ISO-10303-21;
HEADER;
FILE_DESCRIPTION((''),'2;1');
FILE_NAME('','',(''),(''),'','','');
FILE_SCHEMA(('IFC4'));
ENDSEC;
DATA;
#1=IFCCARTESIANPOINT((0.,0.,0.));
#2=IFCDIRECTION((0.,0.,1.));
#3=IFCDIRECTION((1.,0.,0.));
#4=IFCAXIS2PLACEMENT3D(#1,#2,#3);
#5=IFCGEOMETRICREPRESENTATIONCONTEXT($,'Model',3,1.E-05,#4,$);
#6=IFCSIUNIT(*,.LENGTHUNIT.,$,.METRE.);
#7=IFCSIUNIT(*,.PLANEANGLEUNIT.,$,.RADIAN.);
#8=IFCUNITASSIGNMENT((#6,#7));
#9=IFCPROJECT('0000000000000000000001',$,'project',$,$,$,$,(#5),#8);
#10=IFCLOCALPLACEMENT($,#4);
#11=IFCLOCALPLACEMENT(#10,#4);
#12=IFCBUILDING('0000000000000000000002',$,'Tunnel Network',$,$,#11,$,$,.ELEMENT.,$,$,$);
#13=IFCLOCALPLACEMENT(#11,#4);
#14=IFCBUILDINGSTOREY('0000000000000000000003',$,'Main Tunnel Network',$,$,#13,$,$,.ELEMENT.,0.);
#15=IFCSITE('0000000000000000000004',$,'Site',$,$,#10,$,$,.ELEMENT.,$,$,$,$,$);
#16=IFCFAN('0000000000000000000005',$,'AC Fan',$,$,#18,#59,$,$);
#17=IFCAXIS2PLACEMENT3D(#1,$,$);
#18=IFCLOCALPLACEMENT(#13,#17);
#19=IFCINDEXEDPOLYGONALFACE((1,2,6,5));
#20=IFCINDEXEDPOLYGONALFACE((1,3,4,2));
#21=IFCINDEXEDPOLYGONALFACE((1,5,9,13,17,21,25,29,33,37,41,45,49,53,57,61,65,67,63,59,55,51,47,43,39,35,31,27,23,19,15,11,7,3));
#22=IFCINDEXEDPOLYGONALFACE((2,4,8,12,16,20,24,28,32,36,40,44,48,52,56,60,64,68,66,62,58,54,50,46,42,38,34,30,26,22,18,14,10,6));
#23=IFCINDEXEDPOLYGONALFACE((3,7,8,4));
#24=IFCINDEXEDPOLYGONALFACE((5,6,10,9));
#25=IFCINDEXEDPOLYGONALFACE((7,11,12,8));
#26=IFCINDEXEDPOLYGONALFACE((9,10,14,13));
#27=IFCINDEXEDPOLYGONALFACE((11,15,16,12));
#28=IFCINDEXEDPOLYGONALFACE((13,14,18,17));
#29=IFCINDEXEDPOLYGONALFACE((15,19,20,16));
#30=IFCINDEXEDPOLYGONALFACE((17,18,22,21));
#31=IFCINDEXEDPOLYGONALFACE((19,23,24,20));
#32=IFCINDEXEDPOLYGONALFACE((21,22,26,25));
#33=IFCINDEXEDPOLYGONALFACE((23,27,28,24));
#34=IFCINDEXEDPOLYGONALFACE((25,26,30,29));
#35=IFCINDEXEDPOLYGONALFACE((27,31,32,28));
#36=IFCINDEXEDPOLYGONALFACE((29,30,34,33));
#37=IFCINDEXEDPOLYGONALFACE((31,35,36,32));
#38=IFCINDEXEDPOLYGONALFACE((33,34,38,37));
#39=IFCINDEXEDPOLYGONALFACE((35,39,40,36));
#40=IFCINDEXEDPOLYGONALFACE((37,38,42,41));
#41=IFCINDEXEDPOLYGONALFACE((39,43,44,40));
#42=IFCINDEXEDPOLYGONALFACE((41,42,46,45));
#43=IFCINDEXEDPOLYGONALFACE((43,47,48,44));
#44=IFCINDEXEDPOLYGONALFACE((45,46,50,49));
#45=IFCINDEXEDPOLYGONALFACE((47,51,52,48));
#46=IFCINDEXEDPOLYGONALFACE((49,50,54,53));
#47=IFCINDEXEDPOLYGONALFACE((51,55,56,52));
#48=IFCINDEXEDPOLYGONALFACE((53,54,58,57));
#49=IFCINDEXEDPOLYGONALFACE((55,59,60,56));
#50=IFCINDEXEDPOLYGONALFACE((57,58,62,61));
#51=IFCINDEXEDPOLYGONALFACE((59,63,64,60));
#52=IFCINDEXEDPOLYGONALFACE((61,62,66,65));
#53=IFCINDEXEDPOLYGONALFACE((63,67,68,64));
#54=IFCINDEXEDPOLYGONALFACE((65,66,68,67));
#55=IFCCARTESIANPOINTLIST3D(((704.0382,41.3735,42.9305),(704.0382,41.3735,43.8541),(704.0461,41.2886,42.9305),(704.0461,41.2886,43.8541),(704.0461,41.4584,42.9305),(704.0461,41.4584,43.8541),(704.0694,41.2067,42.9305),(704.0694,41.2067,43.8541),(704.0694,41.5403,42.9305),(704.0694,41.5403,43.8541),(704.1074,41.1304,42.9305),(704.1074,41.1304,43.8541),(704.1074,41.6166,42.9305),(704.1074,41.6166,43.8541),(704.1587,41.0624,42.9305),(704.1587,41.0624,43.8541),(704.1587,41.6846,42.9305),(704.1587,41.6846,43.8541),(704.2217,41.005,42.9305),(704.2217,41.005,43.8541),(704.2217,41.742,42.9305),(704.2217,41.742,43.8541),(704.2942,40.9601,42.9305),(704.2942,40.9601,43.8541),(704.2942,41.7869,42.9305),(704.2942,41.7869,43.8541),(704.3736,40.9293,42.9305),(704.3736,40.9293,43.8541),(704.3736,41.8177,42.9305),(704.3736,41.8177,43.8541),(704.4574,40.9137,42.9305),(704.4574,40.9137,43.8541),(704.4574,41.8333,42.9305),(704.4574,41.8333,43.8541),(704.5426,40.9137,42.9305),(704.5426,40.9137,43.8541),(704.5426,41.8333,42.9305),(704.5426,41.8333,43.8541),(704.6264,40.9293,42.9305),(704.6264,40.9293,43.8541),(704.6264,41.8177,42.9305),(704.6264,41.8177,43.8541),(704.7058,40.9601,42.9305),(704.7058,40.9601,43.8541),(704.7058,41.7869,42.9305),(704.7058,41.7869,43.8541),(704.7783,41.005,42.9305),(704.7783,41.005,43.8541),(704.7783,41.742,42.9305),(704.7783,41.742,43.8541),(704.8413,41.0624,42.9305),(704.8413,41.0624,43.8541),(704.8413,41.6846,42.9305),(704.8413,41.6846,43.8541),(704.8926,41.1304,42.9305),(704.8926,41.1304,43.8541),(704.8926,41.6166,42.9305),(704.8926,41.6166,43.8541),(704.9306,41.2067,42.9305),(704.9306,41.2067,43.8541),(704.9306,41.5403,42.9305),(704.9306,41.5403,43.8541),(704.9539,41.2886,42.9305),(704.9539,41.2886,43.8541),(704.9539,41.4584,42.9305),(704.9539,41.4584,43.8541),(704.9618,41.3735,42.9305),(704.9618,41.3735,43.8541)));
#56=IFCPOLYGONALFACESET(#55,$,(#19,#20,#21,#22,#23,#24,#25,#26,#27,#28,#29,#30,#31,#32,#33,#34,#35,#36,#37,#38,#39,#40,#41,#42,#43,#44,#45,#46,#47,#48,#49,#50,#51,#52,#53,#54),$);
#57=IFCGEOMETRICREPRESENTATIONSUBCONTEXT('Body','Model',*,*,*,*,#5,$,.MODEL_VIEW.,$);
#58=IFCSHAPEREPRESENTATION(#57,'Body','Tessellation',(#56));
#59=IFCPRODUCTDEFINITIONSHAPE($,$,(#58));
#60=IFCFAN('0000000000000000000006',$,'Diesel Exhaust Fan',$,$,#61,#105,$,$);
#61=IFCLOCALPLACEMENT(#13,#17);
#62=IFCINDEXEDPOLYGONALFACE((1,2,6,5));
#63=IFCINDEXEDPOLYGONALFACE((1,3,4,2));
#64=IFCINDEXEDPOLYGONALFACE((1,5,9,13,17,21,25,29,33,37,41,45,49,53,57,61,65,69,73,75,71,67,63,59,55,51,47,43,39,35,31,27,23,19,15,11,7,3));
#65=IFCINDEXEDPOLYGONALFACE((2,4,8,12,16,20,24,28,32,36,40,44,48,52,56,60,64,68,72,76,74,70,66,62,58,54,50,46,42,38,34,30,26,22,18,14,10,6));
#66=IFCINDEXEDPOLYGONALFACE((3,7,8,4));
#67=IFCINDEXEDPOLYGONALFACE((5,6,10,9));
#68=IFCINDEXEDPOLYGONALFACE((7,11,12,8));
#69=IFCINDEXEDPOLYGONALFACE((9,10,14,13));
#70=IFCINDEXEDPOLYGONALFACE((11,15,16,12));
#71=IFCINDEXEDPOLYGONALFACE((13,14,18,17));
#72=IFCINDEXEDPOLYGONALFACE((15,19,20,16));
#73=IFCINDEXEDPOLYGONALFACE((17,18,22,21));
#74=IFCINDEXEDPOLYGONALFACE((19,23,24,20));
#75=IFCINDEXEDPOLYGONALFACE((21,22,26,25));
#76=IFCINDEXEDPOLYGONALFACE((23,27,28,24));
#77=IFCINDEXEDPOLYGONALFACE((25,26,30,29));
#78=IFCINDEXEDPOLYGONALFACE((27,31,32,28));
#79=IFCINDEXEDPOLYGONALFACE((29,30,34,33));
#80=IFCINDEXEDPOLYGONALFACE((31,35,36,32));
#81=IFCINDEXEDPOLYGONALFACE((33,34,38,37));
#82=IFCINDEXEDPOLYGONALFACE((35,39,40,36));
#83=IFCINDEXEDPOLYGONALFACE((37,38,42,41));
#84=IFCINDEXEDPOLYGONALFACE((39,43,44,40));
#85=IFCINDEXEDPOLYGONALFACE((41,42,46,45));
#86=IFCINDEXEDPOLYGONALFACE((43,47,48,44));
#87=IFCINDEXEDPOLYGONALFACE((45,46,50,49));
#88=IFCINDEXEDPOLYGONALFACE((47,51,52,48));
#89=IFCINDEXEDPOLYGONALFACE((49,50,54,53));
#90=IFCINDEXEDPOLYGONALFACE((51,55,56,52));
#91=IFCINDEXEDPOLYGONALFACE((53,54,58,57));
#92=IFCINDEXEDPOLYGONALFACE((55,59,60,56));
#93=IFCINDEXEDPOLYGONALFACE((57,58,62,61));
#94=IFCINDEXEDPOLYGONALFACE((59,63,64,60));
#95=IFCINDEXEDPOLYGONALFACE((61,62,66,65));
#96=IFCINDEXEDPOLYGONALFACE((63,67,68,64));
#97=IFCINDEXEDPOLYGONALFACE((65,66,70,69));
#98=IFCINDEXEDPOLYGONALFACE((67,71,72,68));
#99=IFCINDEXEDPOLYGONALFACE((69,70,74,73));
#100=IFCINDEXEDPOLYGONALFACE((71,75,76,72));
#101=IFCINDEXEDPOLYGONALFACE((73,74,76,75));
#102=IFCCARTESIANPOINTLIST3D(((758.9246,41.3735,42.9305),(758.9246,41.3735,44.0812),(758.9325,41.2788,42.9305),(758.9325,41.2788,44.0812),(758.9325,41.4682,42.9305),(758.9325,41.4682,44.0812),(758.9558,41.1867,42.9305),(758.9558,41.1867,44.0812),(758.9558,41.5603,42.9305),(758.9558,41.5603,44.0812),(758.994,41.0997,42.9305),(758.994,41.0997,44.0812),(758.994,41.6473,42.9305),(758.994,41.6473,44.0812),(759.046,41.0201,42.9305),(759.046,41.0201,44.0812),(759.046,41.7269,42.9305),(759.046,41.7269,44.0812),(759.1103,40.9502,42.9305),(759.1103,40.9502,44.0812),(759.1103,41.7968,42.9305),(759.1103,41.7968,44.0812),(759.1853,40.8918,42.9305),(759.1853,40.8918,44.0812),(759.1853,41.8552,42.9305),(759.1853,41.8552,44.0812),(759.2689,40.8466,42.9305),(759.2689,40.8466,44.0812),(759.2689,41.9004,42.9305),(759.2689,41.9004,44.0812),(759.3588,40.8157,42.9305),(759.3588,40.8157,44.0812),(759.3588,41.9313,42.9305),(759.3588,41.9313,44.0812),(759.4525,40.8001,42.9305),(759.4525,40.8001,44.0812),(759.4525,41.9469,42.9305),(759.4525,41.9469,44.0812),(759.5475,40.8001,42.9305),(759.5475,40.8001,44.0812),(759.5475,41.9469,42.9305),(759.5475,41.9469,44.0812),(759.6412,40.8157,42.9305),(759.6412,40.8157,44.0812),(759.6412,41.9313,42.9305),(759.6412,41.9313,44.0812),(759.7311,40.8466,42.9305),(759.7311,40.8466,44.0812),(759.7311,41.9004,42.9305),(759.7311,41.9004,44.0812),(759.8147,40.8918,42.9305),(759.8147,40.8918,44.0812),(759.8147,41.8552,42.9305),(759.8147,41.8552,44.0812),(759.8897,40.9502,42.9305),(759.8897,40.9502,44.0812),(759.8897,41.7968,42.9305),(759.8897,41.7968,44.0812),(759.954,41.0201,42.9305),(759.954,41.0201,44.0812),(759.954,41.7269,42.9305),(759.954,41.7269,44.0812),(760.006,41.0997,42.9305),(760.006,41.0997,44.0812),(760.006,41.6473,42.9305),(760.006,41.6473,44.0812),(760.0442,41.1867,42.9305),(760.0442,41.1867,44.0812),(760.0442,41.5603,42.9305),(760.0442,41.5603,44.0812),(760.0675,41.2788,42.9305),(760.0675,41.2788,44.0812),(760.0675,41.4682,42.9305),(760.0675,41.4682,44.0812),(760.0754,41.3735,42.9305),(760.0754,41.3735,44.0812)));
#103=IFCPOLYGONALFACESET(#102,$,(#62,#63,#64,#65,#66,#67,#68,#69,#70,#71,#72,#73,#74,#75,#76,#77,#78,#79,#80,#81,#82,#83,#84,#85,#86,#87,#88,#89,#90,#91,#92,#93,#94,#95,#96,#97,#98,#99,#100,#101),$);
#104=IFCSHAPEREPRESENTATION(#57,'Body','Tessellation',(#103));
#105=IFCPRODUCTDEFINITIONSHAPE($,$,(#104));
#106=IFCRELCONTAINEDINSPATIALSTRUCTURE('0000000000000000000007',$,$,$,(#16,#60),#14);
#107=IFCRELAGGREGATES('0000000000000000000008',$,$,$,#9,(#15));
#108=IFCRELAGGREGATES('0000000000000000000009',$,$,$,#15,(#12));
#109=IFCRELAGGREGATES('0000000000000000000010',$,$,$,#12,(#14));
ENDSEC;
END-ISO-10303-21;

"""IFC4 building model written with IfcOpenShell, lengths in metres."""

from ifc_helpers import new_model, si_unit, frame, origin_with_axes, origin_2d_with_axis, place, context, subcontext, project, spatial, circle, extrude, element, save


model = new_model("IFC4")

# Units and contexts
model_context = context("Model", 3, precision=1e-05, world=origin_with_axes())
body_context = subcontext(model_context, "Body", "Model", "MODEL_VIEW")
ifc_project = project(units=[si_unit("LENGTHUNIT", "METRE"), si_unit("PLANEANGLEUNIT", "RADIAN")], contexts=[model_context])

# Site, building, storey
site_placement = place(None, origin_with_axes())
site = spatial("IfcSite", under=ifc_project, at=site_placement, Name="Site", CompositionType="ELEMENT")
building_placement = place(site_placement, origin_with_axes())
building = spatial("IfcBuilding", under=site, at=building_placement, Name="Tunnel Network", CompositionType="ELEMENT")
storey_placement = place(building_placement, origin_with_axes())
storey = spatial("IfcBuildingStorey", under=building, at=storey_placement, Name="Main Tunnel Network", CompositionType="ELEMENT", Elevation=0.0)

# Fans
fan_1_placement = place(storey_placement, frame((704.5, 41.3735, 42.9305), z_axis=(0.0, 0.0, 1.0), x_axis=(1.0, 0.0, 0.0)))
element("IfcFan", 1, at=fan_1_placement, inside=storey, Name="AC Fan", context=body_context, shape_type="SweptSolid", body=[
    extrude(circle(Radius=0.4618, at=origin_2d_with_axis()), origin_with_axes(), (0.0, 0.0, 1.0), 0.9236),
])
fan_2_placement = place(storey_placement, frame((759.5, 41.3735, 42.9305), z_axis=(0.0, 0.0, 1.0), x_axis=(1.0, 0.0, 0.0)))
element("IfcFan", 2, at=fan_2_placement, inside=storey, Name="Diesel Exhaust Fan", context=body_context, shape_type="SweptSolid", body=[
    extrude(circle(Radius=0.5754, at=origin_2d_with_axis()), origin_with_axes(), (0.0, 0.0, 1.0), 1.1507),
])

save(model, "model.ifc")
